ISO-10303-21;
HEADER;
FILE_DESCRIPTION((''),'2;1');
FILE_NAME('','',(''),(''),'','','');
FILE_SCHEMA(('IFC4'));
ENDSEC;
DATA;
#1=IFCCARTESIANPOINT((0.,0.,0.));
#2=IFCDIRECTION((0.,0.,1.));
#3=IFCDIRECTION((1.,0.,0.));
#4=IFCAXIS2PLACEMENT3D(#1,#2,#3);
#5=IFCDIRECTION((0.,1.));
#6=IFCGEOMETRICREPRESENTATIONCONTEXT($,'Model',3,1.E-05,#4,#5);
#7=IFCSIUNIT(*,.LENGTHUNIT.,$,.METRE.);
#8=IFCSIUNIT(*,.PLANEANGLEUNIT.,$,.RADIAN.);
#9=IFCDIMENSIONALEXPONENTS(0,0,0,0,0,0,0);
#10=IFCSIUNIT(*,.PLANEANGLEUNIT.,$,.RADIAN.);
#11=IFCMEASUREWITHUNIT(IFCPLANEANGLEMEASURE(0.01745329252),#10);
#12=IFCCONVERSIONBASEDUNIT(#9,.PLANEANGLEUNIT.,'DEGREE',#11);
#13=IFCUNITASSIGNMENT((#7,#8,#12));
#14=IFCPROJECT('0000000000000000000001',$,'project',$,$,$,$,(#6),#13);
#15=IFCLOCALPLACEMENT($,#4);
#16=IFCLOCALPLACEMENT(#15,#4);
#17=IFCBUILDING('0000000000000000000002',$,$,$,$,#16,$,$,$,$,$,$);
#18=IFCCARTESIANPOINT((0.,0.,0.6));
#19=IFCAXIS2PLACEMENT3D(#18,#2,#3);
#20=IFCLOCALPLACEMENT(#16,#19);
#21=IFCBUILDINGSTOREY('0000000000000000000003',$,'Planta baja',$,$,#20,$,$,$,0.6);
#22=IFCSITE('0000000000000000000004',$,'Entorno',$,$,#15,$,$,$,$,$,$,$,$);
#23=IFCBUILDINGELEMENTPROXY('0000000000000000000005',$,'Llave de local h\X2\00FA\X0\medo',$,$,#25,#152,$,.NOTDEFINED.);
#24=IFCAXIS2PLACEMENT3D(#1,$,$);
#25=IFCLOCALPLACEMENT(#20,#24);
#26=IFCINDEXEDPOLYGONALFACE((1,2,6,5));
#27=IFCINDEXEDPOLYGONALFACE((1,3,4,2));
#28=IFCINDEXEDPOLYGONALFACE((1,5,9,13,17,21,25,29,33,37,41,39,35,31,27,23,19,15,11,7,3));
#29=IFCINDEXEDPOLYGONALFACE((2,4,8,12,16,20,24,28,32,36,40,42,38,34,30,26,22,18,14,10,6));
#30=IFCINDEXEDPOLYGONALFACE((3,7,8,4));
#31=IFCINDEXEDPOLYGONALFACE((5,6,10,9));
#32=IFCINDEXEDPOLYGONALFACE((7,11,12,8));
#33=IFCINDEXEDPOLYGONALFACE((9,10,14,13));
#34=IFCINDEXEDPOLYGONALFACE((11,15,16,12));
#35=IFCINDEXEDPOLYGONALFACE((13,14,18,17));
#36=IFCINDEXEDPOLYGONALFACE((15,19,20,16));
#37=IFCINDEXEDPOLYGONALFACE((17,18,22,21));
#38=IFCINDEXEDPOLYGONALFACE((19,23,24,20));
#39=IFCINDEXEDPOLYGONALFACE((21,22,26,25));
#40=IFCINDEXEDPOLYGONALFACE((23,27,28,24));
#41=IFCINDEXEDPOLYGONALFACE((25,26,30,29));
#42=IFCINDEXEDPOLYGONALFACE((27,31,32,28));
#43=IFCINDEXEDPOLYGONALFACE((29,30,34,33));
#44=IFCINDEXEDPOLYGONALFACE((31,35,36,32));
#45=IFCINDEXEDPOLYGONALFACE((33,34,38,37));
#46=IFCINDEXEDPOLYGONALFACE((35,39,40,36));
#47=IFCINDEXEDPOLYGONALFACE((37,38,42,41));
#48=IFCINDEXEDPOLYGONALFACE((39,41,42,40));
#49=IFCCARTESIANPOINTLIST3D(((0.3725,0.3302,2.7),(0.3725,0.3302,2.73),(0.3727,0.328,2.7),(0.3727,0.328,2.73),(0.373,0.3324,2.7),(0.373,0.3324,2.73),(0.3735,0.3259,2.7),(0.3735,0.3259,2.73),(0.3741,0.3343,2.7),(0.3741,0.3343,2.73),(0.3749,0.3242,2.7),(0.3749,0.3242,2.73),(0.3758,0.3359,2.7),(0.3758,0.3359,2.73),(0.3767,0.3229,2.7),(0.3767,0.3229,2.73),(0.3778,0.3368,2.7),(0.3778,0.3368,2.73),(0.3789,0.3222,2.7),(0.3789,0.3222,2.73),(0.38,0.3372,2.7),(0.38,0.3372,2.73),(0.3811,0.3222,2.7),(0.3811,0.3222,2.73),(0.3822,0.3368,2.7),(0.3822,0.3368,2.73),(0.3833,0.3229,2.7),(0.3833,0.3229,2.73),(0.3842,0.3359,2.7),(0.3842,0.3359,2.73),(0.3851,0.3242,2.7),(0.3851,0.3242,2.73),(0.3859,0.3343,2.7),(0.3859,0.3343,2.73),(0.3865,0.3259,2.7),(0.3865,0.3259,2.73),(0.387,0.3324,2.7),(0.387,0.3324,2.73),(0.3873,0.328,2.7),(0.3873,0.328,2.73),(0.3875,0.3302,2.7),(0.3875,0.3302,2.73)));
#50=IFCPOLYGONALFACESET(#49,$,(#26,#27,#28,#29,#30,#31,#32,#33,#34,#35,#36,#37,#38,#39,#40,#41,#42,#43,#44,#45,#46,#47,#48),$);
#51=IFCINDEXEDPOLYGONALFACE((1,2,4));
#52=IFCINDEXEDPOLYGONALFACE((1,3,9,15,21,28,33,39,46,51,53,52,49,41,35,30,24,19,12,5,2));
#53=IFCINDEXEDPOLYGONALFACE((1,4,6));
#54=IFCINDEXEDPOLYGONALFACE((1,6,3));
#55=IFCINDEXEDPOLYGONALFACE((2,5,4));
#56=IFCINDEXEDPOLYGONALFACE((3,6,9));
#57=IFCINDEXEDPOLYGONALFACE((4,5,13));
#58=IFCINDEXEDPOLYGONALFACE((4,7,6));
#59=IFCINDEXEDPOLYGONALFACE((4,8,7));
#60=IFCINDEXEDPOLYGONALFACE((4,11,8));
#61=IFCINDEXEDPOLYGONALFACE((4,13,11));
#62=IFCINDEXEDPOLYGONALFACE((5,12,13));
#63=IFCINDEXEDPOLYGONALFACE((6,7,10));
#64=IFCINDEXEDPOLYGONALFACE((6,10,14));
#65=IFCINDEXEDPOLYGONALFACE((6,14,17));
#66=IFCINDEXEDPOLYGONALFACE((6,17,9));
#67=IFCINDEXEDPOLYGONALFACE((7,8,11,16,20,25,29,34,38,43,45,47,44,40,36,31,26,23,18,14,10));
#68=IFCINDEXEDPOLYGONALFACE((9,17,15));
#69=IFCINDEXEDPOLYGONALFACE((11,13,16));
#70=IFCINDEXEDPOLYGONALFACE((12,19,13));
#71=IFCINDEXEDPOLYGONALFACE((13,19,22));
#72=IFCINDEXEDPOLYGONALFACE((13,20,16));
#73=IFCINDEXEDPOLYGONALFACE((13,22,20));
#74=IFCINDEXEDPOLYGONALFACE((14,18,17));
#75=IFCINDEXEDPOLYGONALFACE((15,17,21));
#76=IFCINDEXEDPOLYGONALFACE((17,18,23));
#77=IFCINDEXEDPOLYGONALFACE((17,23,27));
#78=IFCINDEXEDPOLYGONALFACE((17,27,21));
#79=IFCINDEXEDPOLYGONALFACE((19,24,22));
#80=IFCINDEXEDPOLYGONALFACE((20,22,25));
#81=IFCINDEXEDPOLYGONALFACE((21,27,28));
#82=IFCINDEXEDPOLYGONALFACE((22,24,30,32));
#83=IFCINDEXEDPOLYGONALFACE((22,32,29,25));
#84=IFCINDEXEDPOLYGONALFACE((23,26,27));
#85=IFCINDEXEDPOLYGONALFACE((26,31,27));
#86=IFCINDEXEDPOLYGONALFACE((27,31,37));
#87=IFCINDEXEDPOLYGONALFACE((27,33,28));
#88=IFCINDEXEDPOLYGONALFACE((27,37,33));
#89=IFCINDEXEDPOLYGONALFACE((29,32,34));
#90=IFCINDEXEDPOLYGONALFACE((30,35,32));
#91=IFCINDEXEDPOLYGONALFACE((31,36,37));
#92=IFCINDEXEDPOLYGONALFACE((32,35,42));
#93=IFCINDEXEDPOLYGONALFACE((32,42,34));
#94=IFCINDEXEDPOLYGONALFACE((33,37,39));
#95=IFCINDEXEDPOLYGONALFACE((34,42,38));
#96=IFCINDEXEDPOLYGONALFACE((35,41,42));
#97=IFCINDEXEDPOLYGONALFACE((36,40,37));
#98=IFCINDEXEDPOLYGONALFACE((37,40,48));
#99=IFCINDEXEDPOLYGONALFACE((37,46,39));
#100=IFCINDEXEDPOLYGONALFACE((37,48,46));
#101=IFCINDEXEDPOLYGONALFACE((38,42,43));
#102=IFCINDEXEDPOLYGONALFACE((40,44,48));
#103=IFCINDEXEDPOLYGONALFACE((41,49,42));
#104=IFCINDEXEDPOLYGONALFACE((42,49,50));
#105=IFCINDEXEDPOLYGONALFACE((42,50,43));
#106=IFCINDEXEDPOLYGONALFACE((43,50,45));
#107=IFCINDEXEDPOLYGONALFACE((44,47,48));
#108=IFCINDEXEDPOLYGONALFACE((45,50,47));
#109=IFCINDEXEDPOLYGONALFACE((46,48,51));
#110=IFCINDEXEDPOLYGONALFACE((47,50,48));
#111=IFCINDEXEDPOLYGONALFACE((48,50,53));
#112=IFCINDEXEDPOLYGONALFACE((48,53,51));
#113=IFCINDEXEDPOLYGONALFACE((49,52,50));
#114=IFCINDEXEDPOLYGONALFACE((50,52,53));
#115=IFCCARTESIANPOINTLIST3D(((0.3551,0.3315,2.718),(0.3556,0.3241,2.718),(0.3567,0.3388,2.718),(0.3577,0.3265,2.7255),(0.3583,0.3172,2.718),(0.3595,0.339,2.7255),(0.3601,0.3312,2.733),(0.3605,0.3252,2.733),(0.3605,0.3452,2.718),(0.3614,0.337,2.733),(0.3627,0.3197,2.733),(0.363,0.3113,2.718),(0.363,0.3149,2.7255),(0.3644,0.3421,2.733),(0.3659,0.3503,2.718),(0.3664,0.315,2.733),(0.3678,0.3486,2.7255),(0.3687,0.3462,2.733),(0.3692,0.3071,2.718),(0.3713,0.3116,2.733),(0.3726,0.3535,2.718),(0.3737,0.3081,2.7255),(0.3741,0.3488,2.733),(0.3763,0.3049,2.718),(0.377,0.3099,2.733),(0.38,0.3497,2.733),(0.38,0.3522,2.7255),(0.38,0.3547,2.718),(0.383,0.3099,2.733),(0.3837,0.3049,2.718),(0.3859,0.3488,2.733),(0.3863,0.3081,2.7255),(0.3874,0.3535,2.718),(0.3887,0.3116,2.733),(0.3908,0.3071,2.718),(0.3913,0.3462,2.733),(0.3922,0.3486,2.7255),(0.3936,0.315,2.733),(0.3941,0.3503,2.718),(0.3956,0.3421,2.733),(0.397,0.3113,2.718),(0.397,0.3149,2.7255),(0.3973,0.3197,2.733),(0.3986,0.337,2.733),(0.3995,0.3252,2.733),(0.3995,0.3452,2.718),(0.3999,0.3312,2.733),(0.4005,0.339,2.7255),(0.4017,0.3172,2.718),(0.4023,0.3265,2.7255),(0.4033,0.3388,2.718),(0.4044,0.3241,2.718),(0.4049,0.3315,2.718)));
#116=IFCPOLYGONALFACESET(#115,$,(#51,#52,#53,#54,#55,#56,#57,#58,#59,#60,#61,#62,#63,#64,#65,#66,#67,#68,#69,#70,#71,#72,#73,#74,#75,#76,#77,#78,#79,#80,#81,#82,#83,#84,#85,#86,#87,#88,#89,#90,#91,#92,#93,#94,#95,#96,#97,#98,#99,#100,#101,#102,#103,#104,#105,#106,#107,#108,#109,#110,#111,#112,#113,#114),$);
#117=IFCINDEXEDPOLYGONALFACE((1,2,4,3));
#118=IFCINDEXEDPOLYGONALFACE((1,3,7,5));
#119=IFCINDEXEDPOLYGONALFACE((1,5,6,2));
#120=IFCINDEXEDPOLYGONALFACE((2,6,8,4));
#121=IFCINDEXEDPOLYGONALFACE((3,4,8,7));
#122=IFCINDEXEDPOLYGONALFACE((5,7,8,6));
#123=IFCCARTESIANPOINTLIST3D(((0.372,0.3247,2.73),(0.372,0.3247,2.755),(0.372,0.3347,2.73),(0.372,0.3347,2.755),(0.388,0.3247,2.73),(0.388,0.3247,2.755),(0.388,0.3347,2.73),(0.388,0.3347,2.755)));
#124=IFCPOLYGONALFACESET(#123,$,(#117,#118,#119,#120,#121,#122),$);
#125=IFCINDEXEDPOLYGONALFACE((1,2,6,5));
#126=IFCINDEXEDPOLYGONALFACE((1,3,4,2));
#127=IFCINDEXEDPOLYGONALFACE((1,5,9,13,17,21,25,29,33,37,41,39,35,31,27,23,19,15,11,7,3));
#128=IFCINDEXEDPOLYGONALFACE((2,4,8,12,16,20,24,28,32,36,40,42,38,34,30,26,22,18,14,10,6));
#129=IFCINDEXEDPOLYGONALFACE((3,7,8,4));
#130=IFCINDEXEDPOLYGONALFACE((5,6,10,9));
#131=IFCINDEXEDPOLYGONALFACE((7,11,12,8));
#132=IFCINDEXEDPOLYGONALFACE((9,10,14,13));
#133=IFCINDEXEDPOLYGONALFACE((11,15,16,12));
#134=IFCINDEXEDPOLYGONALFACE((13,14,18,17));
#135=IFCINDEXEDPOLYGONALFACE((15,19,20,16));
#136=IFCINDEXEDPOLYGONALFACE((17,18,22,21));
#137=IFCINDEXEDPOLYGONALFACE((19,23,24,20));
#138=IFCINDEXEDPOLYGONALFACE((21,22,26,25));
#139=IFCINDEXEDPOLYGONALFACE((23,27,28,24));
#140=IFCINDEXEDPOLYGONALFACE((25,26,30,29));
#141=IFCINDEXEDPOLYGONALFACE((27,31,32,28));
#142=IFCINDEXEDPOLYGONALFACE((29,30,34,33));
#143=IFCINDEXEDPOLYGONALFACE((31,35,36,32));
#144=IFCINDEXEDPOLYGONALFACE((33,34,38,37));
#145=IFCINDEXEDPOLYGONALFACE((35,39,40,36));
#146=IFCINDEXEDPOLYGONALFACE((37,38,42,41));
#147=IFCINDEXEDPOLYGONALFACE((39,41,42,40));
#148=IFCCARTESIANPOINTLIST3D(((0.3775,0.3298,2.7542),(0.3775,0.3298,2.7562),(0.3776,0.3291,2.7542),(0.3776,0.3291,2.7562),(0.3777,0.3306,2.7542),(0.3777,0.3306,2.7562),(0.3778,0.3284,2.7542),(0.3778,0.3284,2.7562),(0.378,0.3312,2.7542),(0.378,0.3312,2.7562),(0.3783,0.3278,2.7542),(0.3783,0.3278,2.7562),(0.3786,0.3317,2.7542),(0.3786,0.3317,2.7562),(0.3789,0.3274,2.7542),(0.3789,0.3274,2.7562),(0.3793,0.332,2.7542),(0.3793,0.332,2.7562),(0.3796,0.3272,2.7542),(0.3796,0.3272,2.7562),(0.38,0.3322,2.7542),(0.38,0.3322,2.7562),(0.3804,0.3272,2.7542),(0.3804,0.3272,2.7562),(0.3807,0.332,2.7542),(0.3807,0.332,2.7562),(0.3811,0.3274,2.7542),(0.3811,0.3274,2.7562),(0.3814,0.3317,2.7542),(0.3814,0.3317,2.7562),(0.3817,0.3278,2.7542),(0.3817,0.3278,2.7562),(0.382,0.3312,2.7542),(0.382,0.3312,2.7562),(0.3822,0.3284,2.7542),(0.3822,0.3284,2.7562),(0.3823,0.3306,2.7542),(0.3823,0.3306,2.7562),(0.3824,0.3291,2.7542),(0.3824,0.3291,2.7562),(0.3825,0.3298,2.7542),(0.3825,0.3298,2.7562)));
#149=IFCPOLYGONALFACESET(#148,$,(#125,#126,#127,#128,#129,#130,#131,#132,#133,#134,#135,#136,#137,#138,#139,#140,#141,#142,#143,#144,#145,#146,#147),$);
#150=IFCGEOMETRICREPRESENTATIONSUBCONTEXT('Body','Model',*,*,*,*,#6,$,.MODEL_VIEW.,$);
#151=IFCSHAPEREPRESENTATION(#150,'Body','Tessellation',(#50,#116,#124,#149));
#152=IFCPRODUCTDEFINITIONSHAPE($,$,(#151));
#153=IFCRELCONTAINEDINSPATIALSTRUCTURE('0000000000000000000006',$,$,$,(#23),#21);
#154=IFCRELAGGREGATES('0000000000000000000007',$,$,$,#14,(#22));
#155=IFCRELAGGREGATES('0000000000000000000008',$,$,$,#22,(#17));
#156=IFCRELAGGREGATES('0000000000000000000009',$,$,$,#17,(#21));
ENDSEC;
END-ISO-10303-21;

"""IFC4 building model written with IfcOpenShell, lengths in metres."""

from ifc_helpers import new_model, entity, si_unit, converted_unit, direction, frame, origin_with_axes, place, context, subcontext, project, spatial, polyline, outline, extrude, element, save


model = new_model("IFC4")

# Units and contexts
model_context = context("Model", 3, precision=1e-05, world=origin_with_axes(), true_north=direction((0.0, 1.0)))
body_context = subcontext(model_context, "Body", "Model", "MODEL_VIEW")
ifc_project = project(units=[si_unit("LENGTHUNIT", "METRE"), si_unit("PLANEANGLEUNIT", "RADIAN"), converted_unit("PLANEANGLEUNIT", "DEGREE", entity("IfcPlaneAngleMeasure", 0.01745329252), si_unit("PLANEANGLEUNIT", "RADIAN"), dimensions=[0, 0, 0, 0, 0, 0, 0])], contexts=[model_context])

# Site, building, storey
site_placement = place(None, origin_with_axes())
site = spatial("IfcSite", under=ifc_project, at=site_placement, Name="Entorno")
building_placement = place(site_placement, origin_with_axes())
building = spatial("IfcBuilding", under=site, at=building_placement)
storey_placement = place(building_placement, frame((0.0, 0.0, 0.6), z_axis=(0.0, 0.0, 1.0), x_axis=(1.0, 0.0, 0.0)))
storey = spatial("IfcBuildingStorey", under=building, at=storey_placement, Name="Planta baja", Elevation=0.6)

# Building element proxy
proxy_1_placement = place(storey_placement, frame((0.0, 0.0, -0.6), z_axis=(0.0, 0.0, 1.0), x_axis=(1.0, 0.0, 0.0)))
ifc_direction_1 = entity("IfcDirection", [0.0, 0.0, 1.0])
ifc_direction_2 = entity("IfcDirection", [0.0, 0.0, 1.0])
ifc_direction_3 = entity("IfcDirection", [0.0, 0.0, 1.0])
element("IfcBuildingElementProxy", 1, at=proxy_1_placement, inside=storey, Name="Llave de local húmedo", PredefinedType="NOTDEFINED", context=body_context, shape_type="Brep", body=[
    entity("IfcExtrudedAreaSolidTapered", entity("IfcCircleProfileDef", "AREA", None, entity("IfcAxis2Placement2D", entity("IfcCartesianPoint", [0.0, 0.0]), entity("IfcDirection", [1.0, 0.0])), 0.0075), entity("IfcAxis2Placement3D", entity("IfcCartesianPoint", [0.38, 0.3297, 3.3]), ifc_direction_1, entity("IfcDirection", [0.0, 1.0, 0.0])), ifc_direction_1, 0.03, entity("IfcCircleProfileDef", "AREA", None, entity("IfcAxis2Placement2D", entity("IfcCartesianPoint", [0.0, 0.0]), entity("IfcDirection", [1.0, 0.0])), 0.0075)),
    entity("IfcExtrudedAreaSolidTapered", entity("IfcCircleProfileDef", "AREA", None, entity("IfcAxis2Placement2D", entity("IfcCartesianPoint", [0.0, 0.0]), entity("IfcDirection", [1.0, 0.0])), 0.025), entity("IfcAxis2Placement3D", entity("IfcCartesianPoint", [0.38, 0.3297, 3.318]), ifc_direction_2, entity("IfcDirection", [0.0, 1.0, 0.0])), ifc_direction_2, 0.015, entity("IfcCircleProfileDef", "AREA", None, entity("IfcAxis2Placement2D", entity("IfcCartesianPoint", [0.0, 0.0]), entity("IfcDirection", [1.0, 0.0])), 0.02)),
    extrude(outline(polyline([(0.005, -0.008), (0.005, 0.008), (-0.005, 0.008), (-0.005, -0.008), (0.005, -0.008)])), frame((0.38, 0.3297, 3.33), z_axis=(0.0, 0.0, 1.0), x_axis=(0.0, 1.0, 0.0)), (0.0, 0.0, 1.0), 0.025),
    entity("IfcExtrudedAreaSolidTapered", entity("IfcCircleProfileDef", "AREA", None, entity("IfcAxis2Placement2D", entity("IfcCartesianPoint", [0.0, 0.0]), entity("IfcDirection", [1.0, 0.0])), 0.0025), entity("IfcAxis2Placement3D", entity("IfcCartesianPoint", [0.38, 0.3297, 3.3542]), ifc_direction_3, entity("IfcDirection", [0.0, 1.0, 0.0])), ifc_direction_3, 0.002, entity("IfcCircleProfileDef", "AREA", None, entity("IfcAxis2Placement2D", entity("IfcCartesianPoint", [0.0, 0.0]), entity("IfcDirection", [1.0, 0.0])), 0.0025)),
])

save(model, "model.ifc")
